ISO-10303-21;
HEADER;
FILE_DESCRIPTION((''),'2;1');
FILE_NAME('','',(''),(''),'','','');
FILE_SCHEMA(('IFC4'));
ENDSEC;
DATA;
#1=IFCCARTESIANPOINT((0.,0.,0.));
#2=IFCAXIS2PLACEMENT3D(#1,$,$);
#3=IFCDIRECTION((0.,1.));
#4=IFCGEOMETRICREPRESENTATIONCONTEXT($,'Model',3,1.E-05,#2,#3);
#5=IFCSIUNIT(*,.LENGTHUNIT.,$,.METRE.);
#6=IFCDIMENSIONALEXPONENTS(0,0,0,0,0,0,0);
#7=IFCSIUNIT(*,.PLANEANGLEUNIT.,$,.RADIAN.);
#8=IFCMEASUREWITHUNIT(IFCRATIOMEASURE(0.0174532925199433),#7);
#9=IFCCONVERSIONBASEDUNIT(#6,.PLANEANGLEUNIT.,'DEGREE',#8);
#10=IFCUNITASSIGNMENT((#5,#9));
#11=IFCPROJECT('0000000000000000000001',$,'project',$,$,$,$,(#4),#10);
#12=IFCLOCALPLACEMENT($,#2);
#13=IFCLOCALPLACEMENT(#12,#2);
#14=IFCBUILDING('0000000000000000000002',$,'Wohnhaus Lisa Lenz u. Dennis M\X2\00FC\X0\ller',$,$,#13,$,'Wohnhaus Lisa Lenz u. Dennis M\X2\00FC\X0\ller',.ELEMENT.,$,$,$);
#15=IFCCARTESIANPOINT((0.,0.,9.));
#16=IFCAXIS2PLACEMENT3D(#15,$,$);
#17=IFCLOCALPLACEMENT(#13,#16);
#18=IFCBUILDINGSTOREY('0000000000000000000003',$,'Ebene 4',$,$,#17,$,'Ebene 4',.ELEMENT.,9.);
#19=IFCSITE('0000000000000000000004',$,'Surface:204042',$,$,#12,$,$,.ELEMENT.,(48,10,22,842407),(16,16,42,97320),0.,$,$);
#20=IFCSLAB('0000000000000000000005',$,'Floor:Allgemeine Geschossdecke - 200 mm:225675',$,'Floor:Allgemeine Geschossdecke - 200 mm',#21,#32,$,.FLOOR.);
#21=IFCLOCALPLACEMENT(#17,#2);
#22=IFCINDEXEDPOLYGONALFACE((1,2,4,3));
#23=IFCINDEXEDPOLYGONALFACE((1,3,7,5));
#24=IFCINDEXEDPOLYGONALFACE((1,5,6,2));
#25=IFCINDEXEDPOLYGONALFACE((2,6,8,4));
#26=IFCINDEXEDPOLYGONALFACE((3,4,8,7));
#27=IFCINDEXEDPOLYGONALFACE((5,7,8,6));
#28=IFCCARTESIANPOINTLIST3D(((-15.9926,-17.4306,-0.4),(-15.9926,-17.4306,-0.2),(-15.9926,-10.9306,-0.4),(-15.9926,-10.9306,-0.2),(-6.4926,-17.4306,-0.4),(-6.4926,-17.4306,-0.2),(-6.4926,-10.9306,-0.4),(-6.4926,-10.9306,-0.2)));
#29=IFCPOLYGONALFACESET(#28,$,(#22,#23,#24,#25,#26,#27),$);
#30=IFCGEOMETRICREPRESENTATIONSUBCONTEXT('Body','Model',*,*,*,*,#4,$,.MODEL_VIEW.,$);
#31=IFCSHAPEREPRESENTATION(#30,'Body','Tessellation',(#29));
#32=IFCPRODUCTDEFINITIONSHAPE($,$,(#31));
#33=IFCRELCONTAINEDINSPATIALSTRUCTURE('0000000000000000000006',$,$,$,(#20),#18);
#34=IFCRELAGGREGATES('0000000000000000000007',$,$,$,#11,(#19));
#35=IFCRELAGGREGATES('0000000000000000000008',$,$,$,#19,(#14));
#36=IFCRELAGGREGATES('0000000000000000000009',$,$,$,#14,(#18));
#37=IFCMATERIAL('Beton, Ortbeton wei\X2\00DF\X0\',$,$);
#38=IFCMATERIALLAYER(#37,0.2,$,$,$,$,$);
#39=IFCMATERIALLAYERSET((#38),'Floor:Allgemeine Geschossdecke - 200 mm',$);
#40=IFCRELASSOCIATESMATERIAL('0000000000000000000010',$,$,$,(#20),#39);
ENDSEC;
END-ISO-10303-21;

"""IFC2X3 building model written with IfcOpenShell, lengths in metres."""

from ifc_helpers import new_model, entity, si_unit, converted_unit, direction, frame, frame_2d, origin, place, context, subcontext, project, spatial, rectangle, extrude, material, layer, layer_set, layer_usage, element, save


model = new_model("IFC2X3")

# Units and contexts
model_context = context("Model", 3, precision=1e-05, world=origin(), true_north=direction((0.0, 1.0)))
body_context = subcontext(model_context, "Body", "Model", "MODEL_VIEW")
ifc_project = project(units=[si_unit("LENGTHUNIT", "METRE"), converted_unit("PLANEANGLEUNIT", "DEGREE", entity("IfcRatioMeasure", 0.0174532925199433), si_unit("PLANEANGLEUNIT", "RADIAN"), dimensions=[0, 0, 0, 0, 0, 0, 0])], contexts=[model_context])

# Site, building, storey
site_placement = place(None, origin())
site = spatial("IfcSite", under=ifc_project, at=site_placement, Name="Surface:204042", CompositionType="ELEMENT", RefLatitude=(48, 10, 22, 842407), RefLongitude=(16, 16, 42, 97320), RefElevation=0.0)
building_placement = place(site_placement, origin())
building = spatial("IfcBuilding", under=site, at=building_placement, Name="Wohnhaus Lisa Lenz u. Dennis Müller", LongName="Wohnhaus Lisa Lenz u. Dennis Müller", CompositionType="ELEMENT")
storey_placement = place(building_placement, frame((0.0, 0.0, 9.0)))
storey = spatial("IfcBuildingStorey", under=building, at=storey_placement, Name="Ebene 4", LongName="Ebene 4", CompositionType="ELEMENT", Elevation=9.0)

# Slab
ifc_material = material(Name="Beton, Ortbeton weiß")
ifc_layer = layer(ifc_material, 0.2)
ifc_layer_set = layer_set([ifc_layer], Name="Floor:Allgemeine Geschossdecke - 200 mm")
ifc_layer_usage = layer_usage(ifc_layer_set, "AXIS3", "POSITIVE", 0.0)
slab_placement = place(storey_placement, origin())
element("IfcSlab", 1, at=slab_placement, inside=storey, material=ifc_layer_usage, Name="Floor:Allgemeine Geschossdecke - 200 mm:225675", ObjectType="Floor:Allgemeine Geschossdecke - 200 mm", PredefinedType="FLOOR", context=body_context, shape_type="SweptSolid", body=[
    extrude(rectangle(XDim=6.5, YDim=9.5, at=frame_2d((0.0, 0.0), x_axis=(1.0, 0.0))), frame((-11.2426, -14.1806, -0.2), z_axis=(0.0, 0.0, -1.0), x_axis=(0.0, 1.0, 0.0)), (0.0, 0.0, 1.0), 0.2),
])

save(model, "model.ifc")
